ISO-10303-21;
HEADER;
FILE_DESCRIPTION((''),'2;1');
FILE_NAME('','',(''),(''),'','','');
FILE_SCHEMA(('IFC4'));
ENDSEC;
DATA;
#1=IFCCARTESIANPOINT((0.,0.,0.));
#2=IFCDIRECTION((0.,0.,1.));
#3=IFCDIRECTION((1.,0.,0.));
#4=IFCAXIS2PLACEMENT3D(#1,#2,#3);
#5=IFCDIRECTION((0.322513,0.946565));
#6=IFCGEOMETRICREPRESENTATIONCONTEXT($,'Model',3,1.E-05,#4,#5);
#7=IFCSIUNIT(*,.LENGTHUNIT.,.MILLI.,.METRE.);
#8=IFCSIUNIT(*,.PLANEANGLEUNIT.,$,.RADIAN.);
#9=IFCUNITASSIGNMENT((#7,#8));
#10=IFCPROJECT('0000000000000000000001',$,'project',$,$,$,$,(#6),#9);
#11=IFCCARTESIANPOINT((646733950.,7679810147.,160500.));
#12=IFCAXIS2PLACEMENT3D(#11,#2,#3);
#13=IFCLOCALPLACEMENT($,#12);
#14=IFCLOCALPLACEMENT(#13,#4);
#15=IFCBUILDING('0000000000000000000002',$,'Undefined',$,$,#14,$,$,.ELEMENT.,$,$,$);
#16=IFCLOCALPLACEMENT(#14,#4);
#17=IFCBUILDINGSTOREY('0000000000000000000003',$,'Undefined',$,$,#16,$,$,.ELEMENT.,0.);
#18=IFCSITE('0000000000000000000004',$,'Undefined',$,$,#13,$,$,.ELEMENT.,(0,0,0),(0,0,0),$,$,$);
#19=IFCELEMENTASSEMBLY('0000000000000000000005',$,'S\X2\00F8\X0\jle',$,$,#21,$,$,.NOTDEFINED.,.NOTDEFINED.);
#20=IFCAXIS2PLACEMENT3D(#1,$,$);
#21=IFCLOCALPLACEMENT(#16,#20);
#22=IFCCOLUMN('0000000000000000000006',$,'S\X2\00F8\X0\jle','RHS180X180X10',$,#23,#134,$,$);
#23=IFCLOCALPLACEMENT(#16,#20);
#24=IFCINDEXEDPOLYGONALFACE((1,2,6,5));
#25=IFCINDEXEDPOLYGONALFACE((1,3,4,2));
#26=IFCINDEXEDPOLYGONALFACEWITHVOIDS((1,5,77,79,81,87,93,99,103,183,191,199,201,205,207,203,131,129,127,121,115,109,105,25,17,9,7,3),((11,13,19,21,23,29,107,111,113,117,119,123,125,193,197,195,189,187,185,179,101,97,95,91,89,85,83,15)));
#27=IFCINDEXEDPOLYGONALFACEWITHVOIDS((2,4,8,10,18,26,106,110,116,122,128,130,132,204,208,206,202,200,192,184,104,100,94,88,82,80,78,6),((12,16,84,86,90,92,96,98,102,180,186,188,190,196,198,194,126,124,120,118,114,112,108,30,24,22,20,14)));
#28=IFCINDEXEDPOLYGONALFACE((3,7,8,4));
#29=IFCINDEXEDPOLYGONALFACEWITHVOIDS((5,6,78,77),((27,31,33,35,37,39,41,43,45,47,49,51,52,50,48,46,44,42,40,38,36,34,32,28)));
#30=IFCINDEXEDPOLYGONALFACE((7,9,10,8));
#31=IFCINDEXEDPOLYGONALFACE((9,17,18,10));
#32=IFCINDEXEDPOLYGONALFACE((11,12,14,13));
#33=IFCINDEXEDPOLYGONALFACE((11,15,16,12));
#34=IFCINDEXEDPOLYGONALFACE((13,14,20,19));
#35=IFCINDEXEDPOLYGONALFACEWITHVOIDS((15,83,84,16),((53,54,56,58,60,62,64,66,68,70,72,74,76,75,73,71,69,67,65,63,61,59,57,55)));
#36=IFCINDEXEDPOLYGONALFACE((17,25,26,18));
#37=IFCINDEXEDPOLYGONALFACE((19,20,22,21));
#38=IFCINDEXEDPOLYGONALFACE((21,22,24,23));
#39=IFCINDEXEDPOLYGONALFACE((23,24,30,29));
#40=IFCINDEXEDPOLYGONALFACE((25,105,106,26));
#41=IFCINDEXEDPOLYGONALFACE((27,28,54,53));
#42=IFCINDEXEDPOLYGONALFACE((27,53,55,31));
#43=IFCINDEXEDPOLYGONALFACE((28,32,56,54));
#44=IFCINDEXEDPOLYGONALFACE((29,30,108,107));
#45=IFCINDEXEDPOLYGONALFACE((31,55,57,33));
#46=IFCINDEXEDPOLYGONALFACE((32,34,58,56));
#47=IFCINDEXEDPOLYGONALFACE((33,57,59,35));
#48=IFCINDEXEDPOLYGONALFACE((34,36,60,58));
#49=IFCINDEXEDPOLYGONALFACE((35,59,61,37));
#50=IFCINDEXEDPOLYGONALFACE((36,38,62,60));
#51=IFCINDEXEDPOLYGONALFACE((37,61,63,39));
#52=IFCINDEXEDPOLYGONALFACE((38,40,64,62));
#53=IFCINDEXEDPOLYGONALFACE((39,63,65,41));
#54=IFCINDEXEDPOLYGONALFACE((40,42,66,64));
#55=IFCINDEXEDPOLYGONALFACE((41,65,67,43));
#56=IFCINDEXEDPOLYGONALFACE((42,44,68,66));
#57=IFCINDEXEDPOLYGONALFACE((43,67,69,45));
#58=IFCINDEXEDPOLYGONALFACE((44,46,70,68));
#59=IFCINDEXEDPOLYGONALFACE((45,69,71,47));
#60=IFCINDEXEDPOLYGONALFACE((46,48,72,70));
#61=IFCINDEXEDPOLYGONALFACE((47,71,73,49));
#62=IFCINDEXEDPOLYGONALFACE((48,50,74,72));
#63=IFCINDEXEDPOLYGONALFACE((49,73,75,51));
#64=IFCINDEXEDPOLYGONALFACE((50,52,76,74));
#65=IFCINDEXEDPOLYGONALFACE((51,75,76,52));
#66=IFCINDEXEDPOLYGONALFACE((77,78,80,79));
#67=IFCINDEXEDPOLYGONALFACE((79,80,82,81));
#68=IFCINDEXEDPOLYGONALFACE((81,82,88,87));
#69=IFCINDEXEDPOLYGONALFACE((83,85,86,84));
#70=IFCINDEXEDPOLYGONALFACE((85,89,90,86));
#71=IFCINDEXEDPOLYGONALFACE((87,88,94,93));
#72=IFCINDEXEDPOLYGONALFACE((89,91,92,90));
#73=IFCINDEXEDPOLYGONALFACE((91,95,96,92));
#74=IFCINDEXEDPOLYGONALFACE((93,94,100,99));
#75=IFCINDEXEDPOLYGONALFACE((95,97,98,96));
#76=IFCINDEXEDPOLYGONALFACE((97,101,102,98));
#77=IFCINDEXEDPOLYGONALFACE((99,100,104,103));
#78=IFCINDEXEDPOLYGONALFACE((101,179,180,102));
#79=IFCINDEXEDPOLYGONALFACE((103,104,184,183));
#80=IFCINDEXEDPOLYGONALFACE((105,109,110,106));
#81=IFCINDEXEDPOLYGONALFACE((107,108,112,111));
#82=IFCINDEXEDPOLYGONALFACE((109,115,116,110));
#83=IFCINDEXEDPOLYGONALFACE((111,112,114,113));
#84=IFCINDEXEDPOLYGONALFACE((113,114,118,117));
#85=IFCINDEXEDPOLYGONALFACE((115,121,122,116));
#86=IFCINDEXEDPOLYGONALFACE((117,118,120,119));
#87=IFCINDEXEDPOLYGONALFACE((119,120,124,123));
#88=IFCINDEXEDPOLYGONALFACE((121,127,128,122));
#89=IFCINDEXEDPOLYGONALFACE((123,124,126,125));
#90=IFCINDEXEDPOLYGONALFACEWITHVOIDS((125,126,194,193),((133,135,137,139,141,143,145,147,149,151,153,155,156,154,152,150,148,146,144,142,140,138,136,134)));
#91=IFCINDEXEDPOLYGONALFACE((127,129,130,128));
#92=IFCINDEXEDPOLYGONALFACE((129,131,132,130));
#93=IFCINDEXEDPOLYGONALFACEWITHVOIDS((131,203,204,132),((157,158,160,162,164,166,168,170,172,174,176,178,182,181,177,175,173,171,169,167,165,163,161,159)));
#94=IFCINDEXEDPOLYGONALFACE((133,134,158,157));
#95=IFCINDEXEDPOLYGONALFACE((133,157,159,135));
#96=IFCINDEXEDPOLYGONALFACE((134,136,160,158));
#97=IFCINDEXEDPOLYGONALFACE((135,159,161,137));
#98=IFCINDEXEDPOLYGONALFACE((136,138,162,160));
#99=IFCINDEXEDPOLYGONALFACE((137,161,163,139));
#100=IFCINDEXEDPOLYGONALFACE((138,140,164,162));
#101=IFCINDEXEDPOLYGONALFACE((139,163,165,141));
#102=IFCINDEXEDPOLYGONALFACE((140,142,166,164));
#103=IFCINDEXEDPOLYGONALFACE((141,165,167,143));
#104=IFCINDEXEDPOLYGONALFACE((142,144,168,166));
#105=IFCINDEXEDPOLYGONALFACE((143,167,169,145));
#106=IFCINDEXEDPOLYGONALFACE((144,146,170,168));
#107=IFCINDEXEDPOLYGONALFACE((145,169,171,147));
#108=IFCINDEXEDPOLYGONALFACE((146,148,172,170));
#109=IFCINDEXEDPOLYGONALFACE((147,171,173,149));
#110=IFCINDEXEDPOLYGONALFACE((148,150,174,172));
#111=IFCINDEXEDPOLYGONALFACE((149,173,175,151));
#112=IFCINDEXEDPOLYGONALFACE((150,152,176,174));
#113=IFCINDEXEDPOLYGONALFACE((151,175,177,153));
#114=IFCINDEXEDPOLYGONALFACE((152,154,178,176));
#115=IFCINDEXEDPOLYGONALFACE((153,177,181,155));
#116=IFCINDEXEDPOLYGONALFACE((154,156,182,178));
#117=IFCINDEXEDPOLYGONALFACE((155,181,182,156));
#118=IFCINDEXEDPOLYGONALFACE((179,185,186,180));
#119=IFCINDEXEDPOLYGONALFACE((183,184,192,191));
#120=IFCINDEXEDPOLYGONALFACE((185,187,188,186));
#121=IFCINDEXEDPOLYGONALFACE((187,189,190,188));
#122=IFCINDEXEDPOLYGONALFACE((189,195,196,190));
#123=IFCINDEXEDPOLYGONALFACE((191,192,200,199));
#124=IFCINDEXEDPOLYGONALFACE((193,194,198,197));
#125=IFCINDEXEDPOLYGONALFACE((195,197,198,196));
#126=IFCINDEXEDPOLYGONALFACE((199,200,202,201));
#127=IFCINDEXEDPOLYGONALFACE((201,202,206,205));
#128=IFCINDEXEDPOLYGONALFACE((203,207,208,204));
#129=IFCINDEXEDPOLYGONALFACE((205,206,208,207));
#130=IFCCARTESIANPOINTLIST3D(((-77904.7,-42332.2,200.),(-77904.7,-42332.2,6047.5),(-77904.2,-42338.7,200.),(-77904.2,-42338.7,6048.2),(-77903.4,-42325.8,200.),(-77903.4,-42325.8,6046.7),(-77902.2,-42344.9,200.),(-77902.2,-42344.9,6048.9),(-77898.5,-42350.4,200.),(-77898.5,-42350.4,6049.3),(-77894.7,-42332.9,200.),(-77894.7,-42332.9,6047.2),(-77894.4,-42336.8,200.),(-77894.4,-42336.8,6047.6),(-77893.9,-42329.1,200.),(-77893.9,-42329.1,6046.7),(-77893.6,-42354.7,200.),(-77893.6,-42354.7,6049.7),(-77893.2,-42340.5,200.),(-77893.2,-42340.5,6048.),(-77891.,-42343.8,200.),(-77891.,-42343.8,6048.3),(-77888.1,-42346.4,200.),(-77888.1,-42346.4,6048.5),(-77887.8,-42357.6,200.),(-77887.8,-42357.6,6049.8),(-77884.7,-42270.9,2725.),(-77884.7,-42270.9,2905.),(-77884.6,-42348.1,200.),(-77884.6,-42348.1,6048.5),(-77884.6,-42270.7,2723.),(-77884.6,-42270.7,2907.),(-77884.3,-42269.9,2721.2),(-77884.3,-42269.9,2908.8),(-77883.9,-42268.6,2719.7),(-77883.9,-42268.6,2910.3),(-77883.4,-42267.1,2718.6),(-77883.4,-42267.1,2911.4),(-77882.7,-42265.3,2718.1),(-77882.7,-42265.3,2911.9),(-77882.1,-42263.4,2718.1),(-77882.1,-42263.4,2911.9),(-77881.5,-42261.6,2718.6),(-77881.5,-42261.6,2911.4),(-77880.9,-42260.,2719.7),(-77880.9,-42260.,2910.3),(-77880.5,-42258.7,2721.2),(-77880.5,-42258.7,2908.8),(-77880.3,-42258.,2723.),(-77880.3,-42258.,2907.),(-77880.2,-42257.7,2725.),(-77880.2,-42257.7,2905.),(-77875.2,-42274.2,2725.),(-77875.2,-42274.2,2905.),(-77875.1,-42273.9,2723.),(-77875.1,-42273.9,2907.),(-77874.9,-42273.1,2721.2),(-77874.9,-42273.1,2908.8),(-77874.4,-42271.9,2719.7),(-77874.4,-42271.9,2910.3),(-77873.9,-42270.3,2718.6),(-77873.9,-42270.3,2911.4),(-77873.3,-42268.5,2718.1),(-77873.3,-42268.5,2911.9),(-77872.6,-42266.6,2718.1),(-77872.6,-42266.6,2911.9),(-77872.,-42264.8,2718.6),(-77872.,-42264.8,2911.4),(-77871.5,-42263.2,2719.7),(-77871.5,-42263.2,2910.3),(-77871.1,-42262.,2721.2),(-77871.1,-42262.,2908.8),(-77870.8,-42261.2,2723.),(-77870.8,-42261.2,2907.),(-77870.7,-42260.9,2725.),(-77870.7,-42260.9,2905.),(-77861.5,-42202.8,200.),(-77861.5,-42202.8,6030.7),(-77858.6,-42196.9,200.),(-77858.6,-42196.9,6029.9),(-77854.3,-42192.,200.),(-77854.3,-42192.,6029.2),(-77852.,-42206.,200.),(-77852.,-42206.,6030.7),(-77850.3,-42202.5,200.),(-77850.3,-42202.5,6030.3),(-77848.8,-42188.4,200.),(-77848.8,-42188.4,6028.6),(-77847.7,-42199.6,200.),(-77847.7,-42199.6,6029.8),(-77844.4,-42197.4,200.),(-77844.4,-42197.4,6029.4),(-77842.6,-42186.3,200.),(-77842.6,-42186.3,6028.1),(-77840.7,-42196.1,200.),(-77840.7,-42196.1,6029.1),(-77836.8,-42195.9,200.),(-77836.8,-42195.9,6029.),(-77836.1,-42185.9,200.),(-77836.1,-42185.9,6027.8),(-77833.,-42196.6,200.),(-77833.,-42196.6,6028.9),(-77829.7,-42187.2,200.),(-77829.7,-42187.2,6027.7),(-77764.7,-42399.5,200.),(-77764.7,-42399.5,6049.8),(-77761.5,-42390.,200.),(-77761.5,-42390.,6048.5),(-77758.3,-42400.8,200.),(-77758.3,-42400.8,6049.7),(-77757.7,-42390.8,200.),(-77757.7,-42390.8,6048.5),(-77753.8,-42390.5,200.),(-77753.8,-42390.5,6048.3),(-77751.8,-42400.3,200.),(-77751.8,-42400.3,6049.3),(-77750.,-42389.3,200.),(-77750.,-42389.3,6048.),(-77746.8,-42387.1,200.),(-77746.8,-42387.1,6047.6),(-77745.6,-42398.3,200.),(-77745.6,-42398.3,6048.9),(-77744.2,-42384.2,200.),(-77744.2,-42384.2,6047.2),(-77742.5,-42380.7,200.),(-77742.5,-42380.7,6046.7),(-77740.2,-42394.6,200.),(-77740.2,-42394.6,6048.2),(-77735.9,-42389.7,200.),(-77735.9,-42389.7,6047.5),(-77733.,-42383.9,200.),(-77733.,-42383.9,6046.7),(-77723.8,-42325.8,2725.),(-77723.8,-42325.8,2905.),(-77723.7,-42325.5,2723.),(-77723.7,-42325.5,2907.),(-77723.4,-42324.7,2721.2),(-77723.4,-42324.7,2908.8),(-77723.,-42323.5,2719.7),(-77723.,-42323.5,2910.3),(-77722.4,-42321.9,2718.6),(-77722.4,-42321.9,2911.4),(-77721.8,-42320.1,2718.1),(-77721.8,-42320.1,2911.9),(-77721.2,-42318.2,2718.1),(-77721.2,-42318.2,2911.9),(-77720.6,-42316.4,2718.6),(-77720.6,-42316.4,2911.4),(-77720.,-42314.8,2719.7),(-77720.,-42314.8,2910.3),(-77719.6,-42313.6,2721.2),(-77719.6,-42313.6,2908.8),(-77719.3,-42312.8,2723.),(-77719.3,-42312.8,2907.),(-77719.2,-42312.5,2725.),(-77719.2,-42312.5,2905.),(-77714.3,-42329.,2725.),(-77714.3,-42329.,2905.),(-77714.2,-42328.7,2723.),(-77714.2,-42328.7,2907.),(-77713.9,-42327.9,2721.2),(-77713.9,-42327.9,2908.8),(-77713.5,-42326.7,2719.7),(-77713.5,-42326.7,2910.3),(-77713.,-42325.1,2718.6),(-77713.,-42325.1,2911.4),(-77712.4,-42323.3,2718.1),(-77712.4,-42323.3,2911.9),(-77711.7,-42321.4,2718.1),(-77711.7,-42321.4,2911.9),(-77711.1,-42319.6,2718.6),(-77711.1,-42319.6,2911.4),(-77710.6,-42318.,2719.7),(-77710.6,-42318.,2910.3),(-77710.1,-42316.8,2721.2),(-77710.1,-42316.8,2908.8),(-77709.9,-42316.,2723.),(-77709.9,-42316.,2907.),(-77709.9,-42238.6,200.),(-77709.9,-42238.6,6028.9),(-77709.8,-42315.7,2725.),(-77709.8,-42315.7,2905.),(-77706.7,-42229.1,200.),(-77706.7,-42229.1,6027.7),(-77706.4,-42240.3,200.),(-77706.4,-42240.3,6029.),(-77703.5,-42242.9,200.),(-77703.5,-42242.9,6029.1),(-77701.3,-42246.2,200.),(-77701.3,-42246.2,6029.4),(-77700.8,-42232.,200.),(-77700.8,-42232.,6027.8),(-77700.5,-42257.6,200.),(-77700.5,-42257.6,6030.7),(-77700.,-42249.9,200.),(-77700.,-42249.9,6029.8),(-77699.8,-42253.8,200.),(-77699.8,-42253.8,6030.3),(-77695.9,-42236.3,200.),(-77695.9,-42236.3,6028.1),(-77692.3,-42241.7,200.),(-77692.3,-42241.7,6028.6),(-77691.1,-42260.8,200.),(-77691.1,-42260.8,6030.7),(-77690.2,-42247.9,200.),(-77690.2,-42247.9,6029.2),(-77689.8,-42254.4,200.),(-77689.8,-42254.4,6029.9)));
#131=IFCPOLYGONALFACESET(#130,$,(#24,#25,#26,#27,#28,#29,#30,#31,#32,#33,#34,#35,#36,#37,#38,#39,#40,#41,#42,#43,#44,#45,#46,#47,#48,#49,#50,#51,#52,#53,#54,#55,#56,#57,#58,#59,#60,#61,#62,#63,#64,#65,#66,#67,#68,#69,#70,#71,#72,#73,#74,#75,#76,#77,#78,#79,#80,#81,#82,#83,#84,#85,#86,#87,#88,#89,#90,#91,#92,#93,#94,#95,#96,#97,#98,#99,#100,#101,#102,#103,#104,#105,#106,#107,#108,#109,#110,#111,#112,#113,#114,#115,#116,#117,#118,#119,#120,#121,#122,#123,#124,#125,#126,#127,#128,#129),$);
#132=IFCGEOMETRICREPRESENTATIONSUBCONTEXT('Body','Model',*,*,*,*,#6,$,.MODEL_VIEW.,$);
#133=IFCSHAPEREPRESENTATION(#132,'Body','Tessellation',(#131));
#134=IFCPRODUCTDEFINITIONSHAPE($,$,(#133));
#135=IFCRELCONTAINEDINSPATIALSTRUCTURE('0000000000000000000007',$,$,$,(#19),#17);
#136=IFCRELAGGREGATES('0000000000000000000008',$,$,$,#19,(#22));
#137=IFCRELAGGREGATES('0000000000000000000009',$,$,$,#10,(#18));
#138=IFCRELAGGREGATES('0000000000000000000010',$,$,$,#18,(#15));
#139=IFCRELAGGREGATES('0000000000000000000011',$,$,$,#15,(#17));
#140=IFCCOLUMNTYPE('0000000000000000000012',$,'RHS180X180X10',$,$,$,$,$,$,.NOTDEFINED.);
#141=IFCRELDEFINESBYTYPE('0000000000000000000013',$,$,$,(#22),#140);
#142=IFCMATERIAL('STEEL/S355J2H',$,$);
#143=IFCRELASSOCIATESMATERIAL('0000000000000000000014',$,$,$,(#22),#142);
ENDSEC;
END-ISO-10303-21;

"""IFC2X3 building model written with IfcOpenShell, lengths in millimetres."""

from ifc_helpers import new_model, si_unit, direction, frame, frame_2d, origin_with_axes, origin_2d_with_axis, place, context, subcontext, project, spatial, polyline, circle_curve, parameter, trimmed, segment, composite_curve, hollow_rectangle, outline, extrude, boolean, halfspace, material, type_object, element, aggregate, save


model = new_model("IFC2X3")

# Units and contexts
model_context = context("Model", 3, precision=1e-05, world=origin_with_axes(), true_north=direction((0.322513, 0.946565)))
body_context = subcontext(model_context, "Body", "Model", "MODEL_VIEW")
ifc_project = project(units=[si_unit("LENGTHUNIT", "METRE", prefix="MILLI"), si_unit("PLANEANGLEUNIT", "RADIAN")], contexts=[model_context])

# Site, building, storey
site_placement = place(None, frame((646733950.0, 7679810147.0, 160500.0), z_axis=(0.0, 0.0, 1.0), x_axis=(1.0, 0.0, 0.0)))
site = spatial("IfcSite", under=ifc_project, at=site_placement, Name="Undefined", CompositionType="ELEMENT", RefLatitude=(0, 0, 0), RefLongitude=(0, 0, 0))
building_placement = place(site_placement, origin_with_axes())
building = spatial("IfcBuilding", under=site, at=building_placement, Name="Undefined", CompositionType="ELEMENT")
storey_placement = place(building_placement, origin_with_axes())
storey = spatial("IfcBuildingStorey", under=building, at=storey_placement, Name="Undefined", CompositionType="ELEMENT", Elevation=0.0)

# Element assembly, column
ifc_material_1 = material(Name="STEEL/S355J2H")
assembly_1_placement = place(storey_placement, origin_with_axes())
assembly_1 = element("IfcElementAssembly", 1, at=assembly_1_placement, inside=storey, Name="Søjle", AssemblyPlace="NOTDEFINED", PredefinedType="NOTDEFINED")
column_type_1 = type_object("IfcColumnType", Name="RHS180X180X10", PredefinedType="NOTDEFINED")
column_1_placement = place(assembly_1_placement, frame((-77797.2, -42293.3, 200.0), z_axis=(0.0, 0.0, 1.0), x_axis=(0.322513, 0.946565, 0.0)))
column_1 = element("IfcColumn", 2, at=column_1_placement, type_object=column_type_1, material=ifc_material_1, Name="Søjle", Description="RHS180X180X10", context=body_context, shape_type="CSG", body=[
    boolean("DIFFERENCE", boolean("DIFFERENCE", boolean("DIFFERENCE", extrude(hollow_rectangle(XDim=180.0, YDim=180.0, WallThickness=10.0, InnerFilletRadius=15.0, OuterFilletRadius=25.0, at=origin_2d_with_axis()), frame((0.0, 0.0, 5849.9), z_axis=(0.0, 0.0, -1.0), x_axis=(0.0, 1.0, 0.0)), (0.0, 0.0, 1.0), 5849.9), extrude(outline(composite_curve([segment(trimmed(circle_curve(frame_2d((7.0, 7.0), x_axis=(-1.0, 0.0)), 7.0), [parameter(0.0)], [parameter(1.570796)], True, "PARAMETER"), True, "CONTINUOUS"), segment(polyline([(7.0, 0.0), (187.0, 0.0)]), True, "CONTINUOUS"), segment(trimmed(circle_curve(frame_2d((187.0, 7.0), x_axis=(0.0, -1.0)), 7.0), [parameter(0.0)], [parameter(1.570796)], True, "PARAMETER"), True, "CONTINUOUS"), segment(polyline([(194.0, 7.0), (194.0, 7.0)]), True, "CONTINUOUS"), segment(trimmed(circle_curve(frame_2d((187.0, 7.0), x_axis=(1.0, 0.0)), 7.0), [parameter(0.0)], [parameter(1.570796)], True, "PARAMETER"), True, "CONTINUOUS"), segment(polyline([(187.0, 14.0), (7.0, 14.0)]), True, "CONTINUOUS"), segment(trimmed(circle_curve(frame_2d((7.0, 7.0), x_axis=(0.0, 1.0)), 7.0), [parameter(0.0)], [parameter(1.570796)], True, "PARAMETER"), True, "CONTINUOUS"), segment(polyline([(0.0, 7.0), (0.0, 7.0)]), True, "CONTINUOUS")], self_intersect=True)), frame((-7.0, 96.4, 2712.0), z_axis=(0.0, -1.0, 0.0), x_axis=(0.0, 0.0, -1.0)), (0.0, 0.0, 1.0), 22.7)), extrude(outline(composite_curve([segment(trimmed(circle_curve(frame_2d((7.0, 7.0), x_axis=(-1.0, 0.0)), 7.0), [parameter(0.0)], [parameter(1.570796)], True, "PARAMETER"), True, "CONTINUOUS"), segment(polyline([(7.0, 0.0), (187.0, 0.0)]), True, "CONTINUOUS"), segment(trimmed(circle_curve(frame_2d((187.0, 7.0), x_axis=(0.0, -1.0)), 7.0), [parameter(0.0)], [parameter(1.570796)], True, "PARAMETER"), True, "CONTINUOUS"), segment(polyline([(194.0, 7.0), (194.0, 7.0)]), True, "CONTINUOUS"), segment(trimmed(circle_curve(frame_2d((187.0, 7.0), x_axis=(1.0, 0.0)), 7.0), [parameter(0.0)], [parameter(1.570796)], True, "PARAMETER"), True, "CONTINUOUS"), segment(polyline([(187.0, 14.0), (7.0, 14.0)]), True, "CONTINUOUS"), segment(trimmed(circle_curve(frame_2d((7.0, 7.0), x_axis=(0.0, 1.0)), 7.0), [parameter(0.0)], [parameter(1.570796)], True, "PARAMETER"), True, "CONTINUOUS"), segment(polyline([(0.0, 7.0), (0.0, 7.0)]), True, "CONTINUOUS")], self_intersect=True)), frame((7.0, -96.4, 2712.0), z_axis=(0.0, 1.0, 0.0), x_axis=(0.0, 0.0, -1.0)), (0.0, 0.0, 1.0), 22.7)), halfspace(frame((-90.0, 0.0, 5849.8), z_axis=(-0.121869, 0.0, -0.992546), x_axis=(0.0, -1.0, 0.0)), True)),
])

aggregate(assembly_1, [column_1])

save(model, "model.ifc")
